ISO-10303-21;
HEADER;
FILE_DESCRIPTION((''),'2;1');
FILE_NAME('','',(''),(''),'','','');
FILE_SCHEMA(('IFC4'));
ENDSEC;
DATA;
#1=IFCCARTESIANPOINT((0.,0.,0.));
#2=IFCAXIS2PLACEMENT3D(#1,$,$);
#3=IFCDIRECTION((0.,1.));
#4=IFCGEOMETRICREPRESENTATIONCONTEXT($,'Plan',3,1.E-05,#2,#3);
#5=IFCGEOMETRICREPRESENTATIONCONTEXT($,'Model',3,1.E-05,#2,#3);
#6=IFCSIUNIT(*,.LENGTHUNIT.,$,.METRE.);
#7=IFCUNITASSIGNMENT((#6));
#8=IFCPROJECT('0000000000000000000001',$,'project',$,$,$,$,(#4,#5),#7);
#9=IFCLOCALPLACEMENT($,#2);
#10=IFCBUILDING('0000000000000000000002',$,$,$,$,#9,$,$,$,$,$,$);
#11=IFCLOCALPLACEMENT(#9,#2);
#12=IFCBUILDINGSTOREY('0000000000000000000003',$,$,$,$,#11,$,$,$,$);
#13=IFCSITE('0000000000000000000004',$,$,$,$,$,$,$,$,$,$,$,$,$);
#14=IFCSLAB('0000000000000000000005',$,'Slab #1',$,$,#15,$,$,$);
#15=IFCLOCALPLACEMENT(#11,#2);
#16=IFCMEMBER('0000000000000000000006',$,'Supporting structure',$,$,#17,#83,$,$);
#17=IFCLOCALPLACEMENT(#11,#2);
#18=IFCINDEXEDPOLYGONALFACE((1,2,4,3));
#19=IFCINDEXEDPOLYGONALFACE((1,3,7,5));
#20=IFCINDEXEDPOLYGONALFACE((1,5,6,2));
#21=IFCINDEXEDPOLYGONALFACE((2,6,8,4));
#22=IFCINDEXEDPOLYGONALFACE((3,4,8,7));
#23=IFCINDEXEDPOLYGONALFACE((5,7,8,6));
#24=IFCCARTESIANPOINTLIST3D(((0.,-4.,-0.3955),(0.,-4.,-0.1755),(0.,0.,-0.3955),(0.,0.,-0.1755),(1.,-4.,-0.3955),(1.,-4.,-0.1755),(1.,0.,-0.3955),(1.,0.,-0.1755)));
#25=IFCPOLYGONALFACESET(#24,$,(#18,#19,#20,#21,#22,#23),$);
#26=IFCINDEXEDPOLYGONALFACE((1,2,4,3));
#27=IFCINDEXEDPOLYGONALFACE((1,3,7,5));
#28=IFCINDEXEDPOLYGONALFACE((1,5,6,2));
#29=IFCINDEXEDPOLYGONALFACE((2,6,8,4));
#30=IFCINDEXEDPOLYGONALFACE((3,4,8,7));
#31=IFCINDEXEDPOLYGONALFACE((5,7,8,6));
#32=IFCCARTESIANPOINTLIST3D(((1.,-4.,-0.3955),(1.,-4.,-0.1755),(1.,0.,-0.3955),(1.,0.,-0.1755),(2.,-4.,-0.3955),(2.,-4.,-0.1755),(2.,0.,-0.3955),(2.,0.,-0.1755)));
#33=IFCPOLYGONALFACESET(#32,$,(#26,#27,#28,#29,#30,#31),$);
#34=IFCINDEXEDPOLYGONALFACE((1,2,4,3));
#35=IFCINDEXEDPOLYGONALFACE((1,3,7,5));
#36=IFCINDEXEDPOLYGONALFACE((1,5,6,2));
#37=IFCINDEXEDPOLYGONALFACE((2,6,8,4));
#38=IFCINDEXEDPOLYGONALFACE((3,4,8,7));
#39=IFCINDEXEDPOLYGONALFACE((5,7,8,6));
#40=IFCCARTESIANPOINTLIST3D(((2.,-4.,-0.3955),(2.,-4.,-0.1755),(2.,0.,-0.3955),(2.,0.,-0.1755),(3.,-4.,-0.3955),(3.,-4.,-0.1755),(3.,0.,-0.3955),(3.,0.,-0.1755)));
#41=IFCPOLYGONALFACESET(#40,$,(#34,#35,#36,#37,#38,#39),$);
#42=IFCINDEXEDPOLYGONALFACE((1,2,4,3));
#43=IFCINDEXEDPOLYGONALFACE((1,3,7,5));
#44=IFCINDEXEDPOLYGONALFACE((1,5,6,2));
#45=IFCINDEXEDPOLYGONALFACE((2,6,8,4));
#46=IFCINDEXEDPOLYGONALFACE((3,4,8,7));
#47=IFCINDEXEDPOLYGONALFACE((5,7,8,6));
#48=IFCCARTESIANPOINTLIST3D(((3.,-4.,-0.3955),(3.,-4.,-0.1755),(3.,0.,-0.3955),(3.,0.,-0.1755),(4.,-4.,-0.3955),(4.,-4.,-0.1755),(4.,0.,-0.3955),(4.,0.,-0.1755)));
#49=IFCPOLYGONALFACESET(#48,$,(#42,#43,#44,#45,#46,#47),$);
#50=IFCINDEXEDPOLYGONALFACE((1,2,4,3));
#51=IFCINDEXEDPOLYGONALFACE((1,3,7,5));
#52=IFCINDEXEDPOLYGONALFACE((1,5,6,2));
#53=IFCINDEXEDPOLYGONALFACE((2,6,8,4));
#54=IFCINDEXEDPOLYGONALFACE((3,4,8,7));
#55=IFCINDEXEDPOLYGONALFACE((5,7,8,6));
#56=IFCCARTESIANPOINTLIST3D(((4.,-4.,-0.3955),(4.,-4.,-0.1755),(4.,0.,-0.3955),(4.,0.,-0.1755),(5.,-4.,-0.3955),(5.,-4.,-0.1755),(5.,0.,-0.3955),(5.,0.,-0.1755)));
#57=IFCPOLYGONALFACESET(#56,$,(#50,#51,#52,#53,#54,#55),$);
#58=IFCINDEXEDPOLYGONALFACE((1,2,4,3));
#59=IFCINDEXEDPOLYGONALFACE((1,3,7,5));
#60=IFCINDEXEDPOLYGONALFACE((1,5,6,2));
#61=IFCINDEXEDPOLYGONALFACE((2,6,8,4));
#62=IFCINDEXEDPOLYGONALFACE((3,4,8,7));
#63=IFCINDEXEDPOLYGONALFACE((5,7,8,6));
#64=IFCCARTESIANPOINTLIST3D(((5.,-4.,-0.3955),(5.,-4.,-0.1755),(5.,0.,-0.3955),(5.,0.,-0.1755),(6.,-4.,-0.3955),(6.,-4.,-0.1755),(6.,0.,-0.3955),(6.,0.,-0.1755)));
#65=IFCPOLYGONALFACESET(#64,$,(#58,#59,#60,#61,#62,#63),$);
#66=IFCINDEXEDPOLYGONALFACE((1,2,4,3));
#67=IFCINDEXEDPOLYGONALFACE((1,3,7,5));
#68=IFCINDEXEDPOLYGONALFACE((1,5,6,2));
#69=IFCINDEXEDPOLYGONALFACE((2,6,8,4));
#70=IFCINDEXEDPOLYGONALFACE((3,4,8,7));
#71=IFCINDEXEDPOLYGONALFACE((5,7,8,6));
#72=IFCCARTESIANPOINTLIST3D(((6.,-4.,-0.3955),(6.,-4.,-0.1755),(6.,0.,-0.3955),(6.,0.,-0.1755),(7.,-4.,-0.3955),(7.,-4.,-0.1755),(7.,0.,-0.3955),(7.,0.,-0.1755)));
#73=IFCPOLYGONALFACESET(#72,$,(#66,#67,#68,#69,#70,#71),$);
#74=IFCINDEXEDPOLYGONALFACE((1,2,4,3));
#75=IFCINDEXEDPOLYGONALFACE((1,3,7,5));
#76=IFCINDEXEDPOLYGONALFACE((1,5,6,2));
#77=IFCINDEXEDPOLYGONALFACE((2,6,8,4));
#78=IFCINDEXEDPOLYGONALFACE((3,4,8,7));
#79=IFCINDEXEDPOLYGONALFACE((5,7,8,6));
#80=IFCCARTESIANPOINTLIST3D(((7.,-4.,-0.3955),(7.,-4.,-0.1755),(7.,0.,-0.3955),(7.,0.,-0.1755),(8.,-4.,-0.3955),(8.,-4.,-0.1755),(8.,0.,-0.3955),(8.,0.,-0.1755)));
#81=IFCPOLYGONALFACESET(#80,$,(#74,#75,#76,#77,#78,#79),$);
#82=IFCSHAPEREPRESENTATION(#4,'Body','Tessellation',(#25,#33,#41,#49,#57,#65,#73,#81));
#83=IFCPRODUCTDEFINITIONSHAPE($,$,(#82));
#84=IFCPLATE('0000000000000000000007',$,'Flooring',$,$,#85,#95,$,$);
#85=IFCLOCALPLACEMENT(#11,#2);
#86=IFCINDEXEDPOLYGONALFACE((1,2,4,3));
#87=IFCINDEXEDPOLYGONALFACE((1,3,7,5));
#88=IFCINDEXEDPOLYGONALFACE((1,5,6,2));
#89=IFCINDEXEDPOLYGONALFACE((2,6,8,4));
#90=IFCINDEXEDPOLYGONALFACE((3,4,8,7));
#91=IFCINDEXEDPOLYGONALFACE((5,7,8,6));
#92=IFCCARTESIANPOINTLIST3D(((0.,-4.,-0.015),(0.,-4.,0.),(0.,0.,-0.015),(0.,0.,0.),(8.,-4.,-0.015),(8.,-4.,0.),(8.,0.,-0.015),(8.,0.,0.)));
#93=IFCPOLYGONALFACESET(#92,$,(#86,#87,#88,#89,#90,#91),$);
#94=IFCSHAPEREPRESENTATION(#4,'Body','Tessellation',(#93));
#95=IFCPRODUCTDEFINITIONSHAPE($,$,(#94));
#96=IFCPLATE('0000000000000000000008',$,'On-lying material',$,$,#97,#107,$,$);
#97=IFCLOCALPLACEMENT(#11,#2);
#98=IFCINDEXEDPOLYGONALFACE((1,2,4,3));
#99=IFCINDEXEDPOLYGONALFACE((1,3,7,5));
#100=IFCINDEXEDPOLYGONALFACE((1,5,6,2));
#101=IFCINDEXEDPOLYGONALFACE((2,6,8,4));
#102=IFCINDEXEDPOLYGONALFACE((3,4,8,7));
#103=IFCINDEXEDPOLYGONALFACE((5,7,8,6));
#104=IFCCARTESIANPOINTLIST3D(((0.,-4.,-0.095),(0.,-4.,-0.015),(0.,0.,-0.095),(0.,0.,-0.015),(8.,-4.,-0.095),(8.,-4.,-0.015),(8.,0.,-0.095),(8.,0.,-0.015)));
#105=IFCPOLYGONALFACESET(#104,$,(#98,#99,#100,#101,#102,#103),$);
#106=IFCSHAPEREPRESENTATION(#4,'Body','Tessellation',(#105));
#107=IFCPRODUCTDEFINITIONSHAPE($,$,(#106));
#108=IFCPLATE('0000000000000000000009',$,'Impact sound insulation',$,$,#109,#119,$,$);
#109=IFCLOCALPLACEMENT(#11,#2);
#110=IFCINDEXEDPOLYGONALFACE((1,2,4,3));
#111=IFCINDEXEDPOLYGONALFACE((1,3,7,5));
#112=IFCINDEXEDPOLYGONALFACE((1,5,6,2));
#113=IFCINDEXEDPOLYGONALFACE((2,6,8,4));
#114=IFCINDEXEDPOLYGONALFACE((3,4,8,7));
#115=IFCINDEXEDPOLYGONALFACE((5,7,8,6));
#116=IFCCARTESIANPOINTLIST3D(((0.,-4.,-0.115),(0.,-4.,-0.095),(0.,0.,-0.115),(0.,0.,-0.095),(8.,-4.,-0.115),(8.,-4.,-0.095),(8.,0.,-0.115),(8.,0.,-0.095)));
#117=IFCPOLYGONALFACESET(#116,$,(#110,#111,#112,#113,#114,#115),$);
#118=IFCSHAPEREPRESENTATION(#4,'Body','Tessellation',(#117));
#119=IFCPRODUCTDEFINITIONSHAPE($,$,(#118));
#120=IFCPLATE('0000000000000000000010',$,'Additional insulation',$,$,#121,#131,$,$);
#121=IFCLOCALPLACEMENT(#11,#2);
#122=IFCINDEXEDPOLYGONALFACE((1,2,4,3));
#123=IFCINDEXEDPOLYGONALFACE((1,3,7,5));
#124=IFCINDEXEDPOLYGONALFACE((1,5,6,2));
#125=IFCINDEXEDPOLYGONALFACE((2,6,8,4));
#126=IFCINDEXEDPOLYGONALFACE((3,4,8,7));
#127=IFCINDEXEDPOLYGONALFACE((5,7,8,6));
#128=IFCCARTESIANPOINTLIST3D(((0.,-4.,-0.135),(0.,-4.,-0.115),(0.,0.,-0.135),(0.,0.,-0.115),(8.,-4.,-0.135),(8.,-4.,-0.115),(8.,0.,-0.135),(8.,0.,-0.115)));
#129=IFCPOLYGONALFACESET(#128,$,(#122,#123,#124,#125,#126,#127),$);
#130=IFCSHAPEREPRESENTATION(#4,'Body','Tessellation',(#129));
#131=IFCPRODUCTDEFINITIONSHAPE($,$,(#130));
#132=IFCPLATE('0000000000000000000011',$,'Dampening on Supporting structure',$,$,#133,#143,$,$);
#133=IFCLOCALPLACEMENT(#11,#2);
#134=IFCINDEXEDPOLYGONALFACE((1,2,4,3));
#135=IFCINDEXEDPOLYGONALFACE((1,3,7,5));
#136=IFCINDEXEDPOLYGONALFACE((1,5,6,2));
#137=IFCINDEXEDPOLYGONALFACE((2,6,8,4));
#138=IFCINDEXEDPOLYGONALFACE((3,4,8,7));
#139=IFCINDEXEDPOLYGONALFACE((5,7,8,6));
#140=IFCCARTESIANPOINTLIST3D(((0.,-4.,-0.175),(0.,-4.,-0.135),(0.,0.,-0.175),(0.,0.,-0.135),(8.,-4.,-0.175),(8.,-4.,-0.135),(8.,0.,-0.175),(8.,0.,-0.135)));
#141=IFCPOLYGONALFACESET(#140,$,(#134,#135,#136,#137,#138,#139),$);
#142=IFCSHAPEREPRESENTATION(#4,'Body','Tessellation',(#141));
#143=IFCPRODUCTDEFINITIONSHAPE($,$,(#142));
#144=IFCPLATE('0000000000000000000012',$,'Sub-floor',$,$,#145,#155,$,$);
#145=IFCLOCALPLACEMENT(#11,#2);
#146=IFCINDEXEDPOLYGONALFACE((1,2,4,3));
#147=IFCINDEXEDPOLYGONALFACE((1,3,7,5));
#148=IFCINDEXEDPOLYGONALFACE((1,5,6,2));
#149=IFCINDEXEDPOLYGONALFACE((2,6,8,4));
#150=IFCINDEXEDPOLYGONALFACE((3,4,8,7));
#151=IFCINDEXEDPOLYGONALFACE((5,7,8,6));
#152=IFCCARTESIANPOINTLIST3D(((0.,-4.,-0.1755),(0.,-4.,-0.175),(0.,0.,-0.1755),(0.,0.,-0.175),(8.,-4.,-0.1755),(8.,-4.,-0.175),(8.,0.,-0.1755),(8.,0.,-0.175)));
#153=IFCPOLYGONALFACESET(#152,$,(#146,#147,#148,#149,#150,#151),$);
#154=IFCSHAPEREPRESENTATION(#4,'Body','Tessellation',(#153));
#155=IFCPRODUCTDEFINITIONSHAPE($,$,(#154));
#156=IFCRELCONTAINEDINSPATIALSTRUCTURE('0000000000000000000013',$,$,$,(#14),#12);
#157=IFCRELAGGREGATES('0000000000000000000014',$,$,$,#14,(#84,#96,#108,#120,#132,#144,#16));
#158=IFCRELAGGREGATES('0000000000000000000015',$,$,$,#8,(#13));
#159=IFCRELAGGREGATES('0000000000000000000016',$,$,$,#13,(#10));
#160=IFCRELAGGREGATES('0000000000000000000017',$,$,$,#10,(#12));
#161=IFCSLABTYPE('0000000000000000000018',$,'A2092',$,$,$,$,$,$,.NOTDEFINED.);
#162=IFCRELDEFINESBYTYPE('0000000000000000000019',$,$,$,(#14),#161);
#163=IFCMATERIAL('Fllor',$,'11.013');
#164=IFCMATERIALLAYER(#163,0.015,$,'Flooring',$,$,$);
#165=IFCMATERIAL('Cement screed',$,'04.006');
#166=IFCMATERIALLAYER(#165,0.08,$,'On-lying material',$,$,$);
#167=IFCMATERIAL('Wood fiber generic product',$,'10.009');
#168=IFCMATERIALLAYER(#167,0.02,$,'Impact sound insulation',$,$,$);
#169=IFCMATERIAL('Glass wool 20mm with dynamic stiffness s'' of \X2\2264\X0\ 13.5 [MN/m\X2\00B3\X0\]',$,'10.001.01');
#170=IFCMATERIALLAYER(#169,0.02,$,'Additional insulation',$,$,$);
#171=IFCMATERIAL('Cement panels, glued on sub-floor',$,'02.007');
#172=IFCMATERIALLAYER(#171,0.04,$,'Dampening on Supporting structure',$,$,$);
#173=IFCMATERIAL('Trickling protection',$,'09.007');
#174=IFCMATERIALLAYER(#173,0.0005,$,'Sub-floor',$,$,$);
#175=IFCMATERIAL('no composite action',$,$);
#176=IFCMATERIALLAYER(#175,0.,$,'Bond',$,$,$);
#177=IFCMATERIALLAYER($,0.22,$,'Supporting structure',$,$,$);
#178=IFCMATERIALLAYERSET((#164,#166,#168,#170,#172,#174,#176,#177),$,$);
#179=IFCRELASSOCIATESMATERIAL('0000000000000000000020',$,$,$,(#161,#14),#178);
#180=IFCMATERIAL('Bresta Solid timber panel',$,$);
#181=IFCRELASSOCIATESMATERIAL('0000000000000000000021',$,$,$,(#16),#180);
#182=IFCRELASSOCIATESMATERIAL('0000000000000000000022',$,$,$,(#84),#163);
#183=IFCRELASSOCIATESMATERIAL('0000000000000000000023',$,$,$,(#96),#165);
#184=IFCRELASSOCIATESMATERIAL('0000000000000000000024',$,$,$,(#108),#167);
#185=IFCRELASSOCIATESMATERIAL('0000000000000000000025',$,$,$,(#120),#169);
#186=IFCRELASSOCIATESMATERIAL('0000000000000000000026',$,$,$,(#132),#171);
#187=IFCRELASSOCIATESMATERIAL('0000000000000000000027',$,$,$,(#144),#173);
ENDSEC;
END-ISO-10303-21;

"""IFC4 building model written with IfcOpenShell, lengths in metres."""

from ifc_helpers import new_model, si_unit, direction, frame, frame_2d, origin, origin_with_axes, place, context, project, spatial, rectangle, extrude, material, layer, layer_set, type_object, element, aggregate, save


model = new_model("IFC4")

# Units and contexts
plan_context = context("Plan", 3, precision=1e-05, world=origin(), true_north=direction((0.0, 1.0)))
model_context = context("Model", 3, precision=1e-05, world=origin(), true_north=direction((0.0, 1.0)))
ifc_project = project(units=[si_unit("LENGTHUNIT", "METRE")], contexts=[plan_context, model_context])

# Site, building, storey
site = spatial("IfcSite", under=ifc_project)
building_placement = place(None, origin())
building = spatial("IfcBuilding", under=site, at=building_placement)
storey_placement = place(building_placement, origin())
storey = spatial("IfcBuildingStorey", under=building, at=storey_placement)

# Slab, member, plates
ifc_material_1 = material(Name="Fllor", Category="11.013")
ifc_layer_1 = layer(ifc_material_1, 0.015, Name="Flooring")
ifc_material_2 = material(Name="Cement screed", Category="04.006")
ifc_layer_2 = layer(ifc_material_2, 0.08, Name="On-lying material")
ifc_material_3 = material(Name="Wood fiber generic product", Category="10.009")
ifc_layer_3 = layer(ifc_material_3, 0.02, Name="Impact sound insulation")
ifc_material_4 = material(Name="Glass wool 20mm with dynamic stiffness s' of ≤ 13.5 [MN/m³]", Category="10.001.01")
ifc_layer_4 = layer(ifc_material_4, 0.02, Name="Additional insulation")
ifc_material_5 = material(Name="Cement panels, glued on sub-floor", Category="02.007")
ifc_layer_5 = layer(ifc_material_5, 0.04, Name="Dampening on Supporting structure")
ifc_material_6 = material(Name="Trickling protection", Category="09.007")
ifc_layer_6 = layer(ifc_material_6, 0.0005, Name="Sub-floor")
ifc_material_7 = material(Name="no composite action")
ifc_layer_7 = layer(ifc_material_7, 0.0, Name="Bond")
ifc_layer_8 = layer(None, 0.22, Name="Supporting structure")
ifc_layer_set = layer_set([ifc_layer_1, ifc_layer_2, ifc_layer_3, ifc_layer_4, ifc_layer_5, ifc_layer_6, ifc_layer_7, ifc_layer_8])
slab_type = type_object("IfcSlabType", Name="A2092", PredefinedType="NOTDEFINED", material=ifc_layer_set)
slab_placement = place(None, frame((0.0, 0.0, 0.0), z_axis=(0.0, 0.0, -1.0), x_axis=(1.0, 0.0, 0.0)))
slab = element("IfcSlab", 1, at=slab_placement, inside=storey, type_object=slab_type, material=ifc_layer_set, Name="Slab #1")
ifc_material_8 = material(Name="Bresta Solid timber panel")
member_placement = place(slab_placement, origin())
member = element("IfcMember", 2, at=member_placement, material=ifc_material_8, Name="Supporting structure", context=plan_context, shape_type="SweptSolid", body=[
    extrude(rectangle(XDim=1.0, YDim=0.22, at=frame_2d((0.5, 0.11), x_axis=(1.0, 0.0))), frame((0.0, 4.0, 0.1755), z_axis=(0.0, -1.0, 0.0), x_axis=(1.0, 0.0, 0.0)), (0.0, 0.0, 1.0), 4.0),
    extrude(rectangle(XDim=1.0, YDim=0.22, at=frame_2d((0.5, 0.11), x_axis=(1.0, 0.0))), frame((1.0, 4.0, 0.1755), z_axis=(0.0, -1.0, 0.0), x_axis=(1.0, 0.0, 0.0)), (0.0, 0.0, 1.0), 4.0),
    extrude(rectangle(XDim=1.0, YDim=0.22, at=frame_2d((0.5, 0.11), x_axis=(1.0, 0.0))), frame((2.0, 4.0, 0.1755), z_axis=(0.0, -1.0, 0.0), x_axis=(1.0, 0.0, 0.0)), (0.0, 0.0, 1.0), 4.0),
    extrude(rectangle(XDim=1.0, YDim=0.22, at=frame_2d((0.5, 0.11), x_axis=(1.0, 0.0))), frame((3.0, 4.0, 0.1755), z_axis=(0.0, -1.0, 0.0), x_axis=(1.0, 0.0, 0.0)), (0.0, 0.0, 1.0), 4.0),
    extrude(rectangle(XDim=1.0, YDim=0.22, at=frame_2d((0.5, 0.11), x_axis=(1.0, 0.0))), frame((4.0, 4.0, 0.1755), z_axis=(0.0, -1.0, 0.0), x_axis=(1.0, 0.0, 0.0)), (0.0, 0.0, 1.0), 4.0),
    extrude(rectangle(XDim=1.0, YDim=0.22, at=frame_2d((0.5, 0.11), x_axis=(1.0, 0.0))), frame((5.0, 4.0, 0.1755), z_axis=(0.0, -1.0, 0.0), x_axis=(1.0, 0.0, 0.0)), (0.0, 0.0, 1.0), 4.0),
    extrude(rectangle(XDim=1.0, YDim=0.22, at=frame_2d((0.5, 0.11), x_axis=(1.0, 0.0))), frame((6.0, 4.0, 0.1755), z_axis=(0.0, -1.0, 0.0), x_axis=(1.0, 0.0, 0.0)), (0.0, 0.0, 1.0), 4.0),
    extrude(rectangle(XDim=1.0, YDim=0.22, at=frame_2d((0.5, 0.11), x_axis=(1.0, 0.0))), frame((7.0, 4.0, 0.1755), z_axis=(0.0, -1.0, 0.0), x_axis=(1.0, 0.0, 0.0)), (0.0, 0.0, 1.0), 4.0),
])
plate_1_placement = place(slab_placement, origin())
plate_1 = element("IfcPlate", 3, at=plate_1_placement, material=ifc_material_1, Name="Flooring", context=plan_context, shape_type="SweptSolid", body=[
    extrude(rectangle(XDim=8.0, YDim=4.0, at=frame_2d((4.0, 2.0), x_axis=(1.0, 0.0))), origin_with_axes(), (0.0, 0.0, 1.0), 0.015),
])
plate_2_placement = place(slab_placement, origin())
plate_2 = element("IfcPlate", 4, at=plate_2_placement, material=ifc_material_2, Name="On-lying material", context=plan_context, shape_type="SweptSolid", body=[
    extrude(rectangle(XDim=8.0, YDim=4.0, at=frame_2d((4.0, 2.0), x_axis=(1.0, 0.0))), frame((0.0, 0.0, 0.015), z_axis=(0.0, 0.0, 1.0), x_axis=(1.0, 0.0, 0.0)), (0.0, 0.0, 1.0), 0.08),
])
plate_3_placement = place(slab_placement, origin())
plate_3 = element("IfcPlate", 5, at=plate_3_placement, material=ifc_material_3, Name="Impact sound insulation", context=plan_context, shape_type="SweptSolid", body=[
    extrude(rectangle(XDim=8.0, YDim=4.0, at=frame_2d((4.0, 2.0), x_axis=(1.0, 0.0))), frame((0.0, 0.0, 0.095), z_axis=(0.0, 0.0, 1.0), x_axis=(1.0, 0.0, 0.0)), (0.0, 0.0, 1.0), 0.02),
])
plate_4_placement = place(slab_placement, origin())
plate_4 = element("IfcPlate", 6, at=plate_4_placement, material=ifc_material_4, Name="Additional insulation", context=plan_context, shape_type="SweptSolid", body=[
    extrude(rectangle(XDim=8.0, YDim=4.0, at=frame_2d((4.0, 2.0), x_axis=(1.0, 0.0))), frame((0.0, 0.0, 0.115), z_axis=(0.0, 0.0, 1.0), x_axis=(1.0, 0.0, 0.0)), (0.0, 0.0, 1.0), 0.02),
])
plate_5_placement = place(slab_placement, origin())
plate_5 = element("IfcPlate", 7, at=plate_5_placement, material=ifc_material_5, Name="Dampening on Supporting structure", context=plan_context, shape_type="SweptSolid", body=[
    extrude(rectangle(XDim=8.0, YDim=4.0, at=frame_2d((4.0, 2.0), x_axis=(1.0, 0.0))), frame((0.0, 0.0, 0.135), z_axis=(0.0, 0.0, 1.0), x_axis=(1.0, 0.0, 0.0)), (0.0, 0.0, 1.0), 0.04),
])
plate_6_placement = place(slab_placement, origin())
plate_6 = element("IfcPlate", 8, at=plate_6_placement, material=ifc_material_6, Name="Sub-floor", context=plan_context, shape_type="SweptSolid", body=[
    extrude(rectangle(XDim=8.0, YDim=4.0, at=frame_2d((4.0, 2.0), x_axis=(1.0, 0.0))), frame((0.0, 0.0, 0.175), z_axis=(0.0, 0.0, 1.0), x_axis=(1.0, 0.0, 0.0)), (0.0, 0.0, 1.0), 0.0005),
])
aggregate(slab, [plate_1, plate_2, plate_3, plate_4, plate_5, plate_6, member])

save(model, "model.ifc")
